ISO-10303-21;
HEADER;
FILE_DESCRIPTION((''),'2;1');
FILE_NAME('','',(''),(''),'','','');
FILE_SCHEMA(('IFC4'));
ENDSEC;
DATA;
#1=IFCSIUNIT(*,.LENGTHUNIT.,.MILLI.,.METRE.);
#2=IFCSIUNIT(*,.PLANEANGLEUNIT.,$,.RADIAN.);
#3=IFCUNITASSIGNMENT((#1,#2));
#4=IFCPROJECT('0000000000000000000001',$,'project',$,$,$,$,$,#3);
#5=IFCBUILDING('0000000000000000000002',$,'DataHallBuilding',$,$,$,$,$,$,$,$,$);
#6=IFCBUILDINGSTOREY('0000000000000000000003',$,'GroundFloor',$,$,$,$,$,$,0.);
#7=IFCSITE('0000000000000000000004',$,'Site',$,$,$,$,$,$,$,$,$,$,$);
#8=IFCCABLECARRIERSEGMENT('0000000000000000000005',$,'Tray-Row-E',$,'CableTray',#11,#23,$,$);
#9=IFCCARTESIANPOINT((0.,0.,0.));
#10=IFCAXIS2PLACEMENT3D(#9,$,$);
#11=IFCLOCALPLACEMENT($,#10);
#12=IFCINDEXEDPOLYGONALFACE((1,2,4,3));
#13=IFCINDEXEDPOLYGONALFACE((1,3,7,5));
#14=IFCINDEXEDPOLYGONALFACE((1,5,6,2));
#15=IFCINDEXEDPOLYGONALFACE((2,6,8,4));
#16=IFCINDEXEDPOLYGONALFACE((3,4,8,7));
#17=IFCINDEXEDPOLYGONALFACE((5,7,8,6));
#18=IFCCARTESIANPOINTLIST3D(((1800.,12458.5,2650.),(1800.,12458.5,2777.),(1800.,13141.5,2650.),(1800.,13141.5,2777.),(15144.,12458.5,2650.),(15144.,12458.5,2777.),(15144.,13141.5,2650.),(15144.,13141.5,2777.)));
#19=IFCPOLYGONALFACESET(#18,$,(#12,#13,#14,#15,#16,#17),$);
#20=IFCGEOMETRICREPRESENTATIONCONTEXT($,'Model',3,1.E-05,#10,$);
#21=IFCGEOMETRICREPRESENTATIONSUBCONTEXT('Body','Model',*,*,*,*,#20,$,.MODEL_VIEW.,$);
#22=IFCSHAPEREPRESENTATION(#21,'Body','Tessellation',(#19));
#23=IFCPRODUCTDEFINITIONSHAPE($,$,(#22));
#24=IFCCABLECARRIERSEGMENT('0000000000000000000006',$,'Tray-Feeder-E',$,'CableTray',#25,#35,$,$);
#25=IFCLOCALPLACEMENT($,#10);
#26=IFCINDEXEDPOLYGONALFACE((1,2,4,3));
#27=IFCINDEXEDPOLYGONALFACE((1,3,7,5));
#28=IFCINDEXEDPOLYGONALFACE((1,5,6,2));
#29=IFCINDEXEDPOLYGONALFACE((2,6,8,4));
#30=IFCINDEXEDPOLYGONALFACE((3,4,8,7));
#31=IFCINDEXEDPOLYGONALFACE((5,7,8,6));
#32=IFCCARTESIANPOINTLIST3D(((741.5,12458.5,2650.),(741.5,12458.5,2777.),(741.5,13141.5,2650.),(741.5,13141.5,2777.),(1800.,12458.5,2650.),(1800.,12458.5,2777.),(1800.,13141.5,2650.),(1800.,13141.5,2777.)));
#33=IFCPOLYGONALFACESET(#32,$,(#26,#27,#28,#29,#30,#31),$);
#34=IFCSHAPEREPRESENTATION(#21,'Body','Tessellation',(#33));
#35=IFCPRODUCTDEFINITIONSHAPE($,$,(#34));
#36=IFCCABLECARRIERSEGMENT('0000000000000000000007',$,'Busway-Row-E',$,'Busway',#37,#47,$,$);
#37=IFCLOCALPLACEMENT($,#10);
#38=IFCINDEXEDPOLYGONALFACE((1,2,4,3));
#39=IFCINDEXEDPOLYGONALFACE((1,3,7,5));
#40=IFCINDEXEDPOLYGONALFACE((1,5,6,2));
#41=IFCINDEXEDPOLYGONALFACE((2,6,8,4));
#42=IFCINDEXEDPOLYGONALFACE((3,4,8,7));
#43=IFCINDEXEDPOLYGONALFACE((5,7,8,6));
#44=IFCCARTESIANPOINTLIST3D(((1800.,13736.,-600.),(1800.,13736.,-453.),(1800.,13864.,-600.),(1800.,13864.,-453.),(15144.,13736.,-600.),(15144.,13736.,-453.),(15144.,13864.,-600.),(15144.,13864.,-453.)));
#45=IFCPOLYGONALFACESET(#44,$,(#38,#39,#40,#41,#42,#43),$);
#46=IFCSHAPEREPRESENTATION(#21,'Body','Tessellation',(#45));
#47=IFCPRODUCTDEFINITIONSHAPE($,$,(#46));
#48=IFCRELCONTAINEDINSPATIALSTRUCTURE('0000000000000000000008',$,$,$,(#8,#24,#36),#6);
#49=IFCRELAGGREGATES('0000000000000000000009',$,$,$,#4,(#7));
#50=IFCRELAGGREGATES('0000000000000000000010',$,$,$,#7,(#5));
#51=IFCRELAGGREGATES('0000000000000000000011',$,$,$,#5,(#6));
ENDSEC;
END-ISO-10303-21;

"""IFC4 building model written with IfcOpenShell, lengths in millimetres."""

from ifc_helpers import new_model, si_unit, frame, origin, place, context, subcontext, project, spatial, rectangle, extrude, element, save


model = new_model("IFC4")

# Units and contexts
model_context = context("Model", 3, precision=1e-05, world=origin())
body_context = subcontext(model_context, "Body", "Model", "MODEL_VIEW")
ifc_project = project(units=[si_unit("LENGTHUNIT", "METRE", prefix="MILLI"), si_unit("PLANEANGLEUNIT", "RADIAN")])

# Site, building, storey
site = spatial("IfcSite", under=ifc_project, Name="Site")
building = spatial("IfcBuilding", under=site, Name="DataHallBuilding")
storey = spatial("IfcBuildingStorey", under=building, Name="GroundFloor", Elevation=0.0)

# Cable carrier segments
cable_carrier_segment_1_placement = place(None, origin())
element("IfcCableCarrierSegment", 1, at=cable_carrier_segment_1_placement, inside=storey, Name="Tray-Row-E", ObjectType="CableTray", context=body_context, shape_type="SweptSolid", body=[
    extrude(rectangle(XDim=13344.0, YDim=683.0), frame((8472.0, 12800.0, 2650.0), z_axis=(0.0, 0.0, 1.0), x_axis=(1.0, 0.0, 0.0)), (0.0, 0.0, 1.0), 127.0),
])
cable_carrier_segment_2_placement = place(None, origin())
element("IfcCableCarrierSegment", 2, at=cable_carrier_segment_2_placement, inside=storey, Name="Tray-Feeder-E", ObjectType="CableTray", context=body_context, shape_type="SweptSolid", body=[
    extrude(rectangle(XDim=1058.5, YDim=683.0), frame((1270.8, 12800.0, 2650.0), z_axis=(0.0, 0.0, 1.0), x_axis=(1.0, 0.0, 0.0)), (0.0, 0.0, 1.0), 127.0),
])
cable_carrier_segment_3_placement = place(None, origin())
element("IfcCableCarrierSegment", 3, at=cable_carrier_segment_3_placement, inside=storey, Name="Busway-Row-E", ObjectType="Busway", context=body_context, shape_type="SweptSolid", body=[
    extrude(rectangle(XDim=13344.0, YDim=128.0), frame((8472.0, 13800.0, -600.0), z_axis=(0.0, 0.0, 1.0), x_axis=(1.0, 0.0, 0.0)), (0.0, 0.0, 1.0), 147.0),
])

save(model, "model.ifc")
